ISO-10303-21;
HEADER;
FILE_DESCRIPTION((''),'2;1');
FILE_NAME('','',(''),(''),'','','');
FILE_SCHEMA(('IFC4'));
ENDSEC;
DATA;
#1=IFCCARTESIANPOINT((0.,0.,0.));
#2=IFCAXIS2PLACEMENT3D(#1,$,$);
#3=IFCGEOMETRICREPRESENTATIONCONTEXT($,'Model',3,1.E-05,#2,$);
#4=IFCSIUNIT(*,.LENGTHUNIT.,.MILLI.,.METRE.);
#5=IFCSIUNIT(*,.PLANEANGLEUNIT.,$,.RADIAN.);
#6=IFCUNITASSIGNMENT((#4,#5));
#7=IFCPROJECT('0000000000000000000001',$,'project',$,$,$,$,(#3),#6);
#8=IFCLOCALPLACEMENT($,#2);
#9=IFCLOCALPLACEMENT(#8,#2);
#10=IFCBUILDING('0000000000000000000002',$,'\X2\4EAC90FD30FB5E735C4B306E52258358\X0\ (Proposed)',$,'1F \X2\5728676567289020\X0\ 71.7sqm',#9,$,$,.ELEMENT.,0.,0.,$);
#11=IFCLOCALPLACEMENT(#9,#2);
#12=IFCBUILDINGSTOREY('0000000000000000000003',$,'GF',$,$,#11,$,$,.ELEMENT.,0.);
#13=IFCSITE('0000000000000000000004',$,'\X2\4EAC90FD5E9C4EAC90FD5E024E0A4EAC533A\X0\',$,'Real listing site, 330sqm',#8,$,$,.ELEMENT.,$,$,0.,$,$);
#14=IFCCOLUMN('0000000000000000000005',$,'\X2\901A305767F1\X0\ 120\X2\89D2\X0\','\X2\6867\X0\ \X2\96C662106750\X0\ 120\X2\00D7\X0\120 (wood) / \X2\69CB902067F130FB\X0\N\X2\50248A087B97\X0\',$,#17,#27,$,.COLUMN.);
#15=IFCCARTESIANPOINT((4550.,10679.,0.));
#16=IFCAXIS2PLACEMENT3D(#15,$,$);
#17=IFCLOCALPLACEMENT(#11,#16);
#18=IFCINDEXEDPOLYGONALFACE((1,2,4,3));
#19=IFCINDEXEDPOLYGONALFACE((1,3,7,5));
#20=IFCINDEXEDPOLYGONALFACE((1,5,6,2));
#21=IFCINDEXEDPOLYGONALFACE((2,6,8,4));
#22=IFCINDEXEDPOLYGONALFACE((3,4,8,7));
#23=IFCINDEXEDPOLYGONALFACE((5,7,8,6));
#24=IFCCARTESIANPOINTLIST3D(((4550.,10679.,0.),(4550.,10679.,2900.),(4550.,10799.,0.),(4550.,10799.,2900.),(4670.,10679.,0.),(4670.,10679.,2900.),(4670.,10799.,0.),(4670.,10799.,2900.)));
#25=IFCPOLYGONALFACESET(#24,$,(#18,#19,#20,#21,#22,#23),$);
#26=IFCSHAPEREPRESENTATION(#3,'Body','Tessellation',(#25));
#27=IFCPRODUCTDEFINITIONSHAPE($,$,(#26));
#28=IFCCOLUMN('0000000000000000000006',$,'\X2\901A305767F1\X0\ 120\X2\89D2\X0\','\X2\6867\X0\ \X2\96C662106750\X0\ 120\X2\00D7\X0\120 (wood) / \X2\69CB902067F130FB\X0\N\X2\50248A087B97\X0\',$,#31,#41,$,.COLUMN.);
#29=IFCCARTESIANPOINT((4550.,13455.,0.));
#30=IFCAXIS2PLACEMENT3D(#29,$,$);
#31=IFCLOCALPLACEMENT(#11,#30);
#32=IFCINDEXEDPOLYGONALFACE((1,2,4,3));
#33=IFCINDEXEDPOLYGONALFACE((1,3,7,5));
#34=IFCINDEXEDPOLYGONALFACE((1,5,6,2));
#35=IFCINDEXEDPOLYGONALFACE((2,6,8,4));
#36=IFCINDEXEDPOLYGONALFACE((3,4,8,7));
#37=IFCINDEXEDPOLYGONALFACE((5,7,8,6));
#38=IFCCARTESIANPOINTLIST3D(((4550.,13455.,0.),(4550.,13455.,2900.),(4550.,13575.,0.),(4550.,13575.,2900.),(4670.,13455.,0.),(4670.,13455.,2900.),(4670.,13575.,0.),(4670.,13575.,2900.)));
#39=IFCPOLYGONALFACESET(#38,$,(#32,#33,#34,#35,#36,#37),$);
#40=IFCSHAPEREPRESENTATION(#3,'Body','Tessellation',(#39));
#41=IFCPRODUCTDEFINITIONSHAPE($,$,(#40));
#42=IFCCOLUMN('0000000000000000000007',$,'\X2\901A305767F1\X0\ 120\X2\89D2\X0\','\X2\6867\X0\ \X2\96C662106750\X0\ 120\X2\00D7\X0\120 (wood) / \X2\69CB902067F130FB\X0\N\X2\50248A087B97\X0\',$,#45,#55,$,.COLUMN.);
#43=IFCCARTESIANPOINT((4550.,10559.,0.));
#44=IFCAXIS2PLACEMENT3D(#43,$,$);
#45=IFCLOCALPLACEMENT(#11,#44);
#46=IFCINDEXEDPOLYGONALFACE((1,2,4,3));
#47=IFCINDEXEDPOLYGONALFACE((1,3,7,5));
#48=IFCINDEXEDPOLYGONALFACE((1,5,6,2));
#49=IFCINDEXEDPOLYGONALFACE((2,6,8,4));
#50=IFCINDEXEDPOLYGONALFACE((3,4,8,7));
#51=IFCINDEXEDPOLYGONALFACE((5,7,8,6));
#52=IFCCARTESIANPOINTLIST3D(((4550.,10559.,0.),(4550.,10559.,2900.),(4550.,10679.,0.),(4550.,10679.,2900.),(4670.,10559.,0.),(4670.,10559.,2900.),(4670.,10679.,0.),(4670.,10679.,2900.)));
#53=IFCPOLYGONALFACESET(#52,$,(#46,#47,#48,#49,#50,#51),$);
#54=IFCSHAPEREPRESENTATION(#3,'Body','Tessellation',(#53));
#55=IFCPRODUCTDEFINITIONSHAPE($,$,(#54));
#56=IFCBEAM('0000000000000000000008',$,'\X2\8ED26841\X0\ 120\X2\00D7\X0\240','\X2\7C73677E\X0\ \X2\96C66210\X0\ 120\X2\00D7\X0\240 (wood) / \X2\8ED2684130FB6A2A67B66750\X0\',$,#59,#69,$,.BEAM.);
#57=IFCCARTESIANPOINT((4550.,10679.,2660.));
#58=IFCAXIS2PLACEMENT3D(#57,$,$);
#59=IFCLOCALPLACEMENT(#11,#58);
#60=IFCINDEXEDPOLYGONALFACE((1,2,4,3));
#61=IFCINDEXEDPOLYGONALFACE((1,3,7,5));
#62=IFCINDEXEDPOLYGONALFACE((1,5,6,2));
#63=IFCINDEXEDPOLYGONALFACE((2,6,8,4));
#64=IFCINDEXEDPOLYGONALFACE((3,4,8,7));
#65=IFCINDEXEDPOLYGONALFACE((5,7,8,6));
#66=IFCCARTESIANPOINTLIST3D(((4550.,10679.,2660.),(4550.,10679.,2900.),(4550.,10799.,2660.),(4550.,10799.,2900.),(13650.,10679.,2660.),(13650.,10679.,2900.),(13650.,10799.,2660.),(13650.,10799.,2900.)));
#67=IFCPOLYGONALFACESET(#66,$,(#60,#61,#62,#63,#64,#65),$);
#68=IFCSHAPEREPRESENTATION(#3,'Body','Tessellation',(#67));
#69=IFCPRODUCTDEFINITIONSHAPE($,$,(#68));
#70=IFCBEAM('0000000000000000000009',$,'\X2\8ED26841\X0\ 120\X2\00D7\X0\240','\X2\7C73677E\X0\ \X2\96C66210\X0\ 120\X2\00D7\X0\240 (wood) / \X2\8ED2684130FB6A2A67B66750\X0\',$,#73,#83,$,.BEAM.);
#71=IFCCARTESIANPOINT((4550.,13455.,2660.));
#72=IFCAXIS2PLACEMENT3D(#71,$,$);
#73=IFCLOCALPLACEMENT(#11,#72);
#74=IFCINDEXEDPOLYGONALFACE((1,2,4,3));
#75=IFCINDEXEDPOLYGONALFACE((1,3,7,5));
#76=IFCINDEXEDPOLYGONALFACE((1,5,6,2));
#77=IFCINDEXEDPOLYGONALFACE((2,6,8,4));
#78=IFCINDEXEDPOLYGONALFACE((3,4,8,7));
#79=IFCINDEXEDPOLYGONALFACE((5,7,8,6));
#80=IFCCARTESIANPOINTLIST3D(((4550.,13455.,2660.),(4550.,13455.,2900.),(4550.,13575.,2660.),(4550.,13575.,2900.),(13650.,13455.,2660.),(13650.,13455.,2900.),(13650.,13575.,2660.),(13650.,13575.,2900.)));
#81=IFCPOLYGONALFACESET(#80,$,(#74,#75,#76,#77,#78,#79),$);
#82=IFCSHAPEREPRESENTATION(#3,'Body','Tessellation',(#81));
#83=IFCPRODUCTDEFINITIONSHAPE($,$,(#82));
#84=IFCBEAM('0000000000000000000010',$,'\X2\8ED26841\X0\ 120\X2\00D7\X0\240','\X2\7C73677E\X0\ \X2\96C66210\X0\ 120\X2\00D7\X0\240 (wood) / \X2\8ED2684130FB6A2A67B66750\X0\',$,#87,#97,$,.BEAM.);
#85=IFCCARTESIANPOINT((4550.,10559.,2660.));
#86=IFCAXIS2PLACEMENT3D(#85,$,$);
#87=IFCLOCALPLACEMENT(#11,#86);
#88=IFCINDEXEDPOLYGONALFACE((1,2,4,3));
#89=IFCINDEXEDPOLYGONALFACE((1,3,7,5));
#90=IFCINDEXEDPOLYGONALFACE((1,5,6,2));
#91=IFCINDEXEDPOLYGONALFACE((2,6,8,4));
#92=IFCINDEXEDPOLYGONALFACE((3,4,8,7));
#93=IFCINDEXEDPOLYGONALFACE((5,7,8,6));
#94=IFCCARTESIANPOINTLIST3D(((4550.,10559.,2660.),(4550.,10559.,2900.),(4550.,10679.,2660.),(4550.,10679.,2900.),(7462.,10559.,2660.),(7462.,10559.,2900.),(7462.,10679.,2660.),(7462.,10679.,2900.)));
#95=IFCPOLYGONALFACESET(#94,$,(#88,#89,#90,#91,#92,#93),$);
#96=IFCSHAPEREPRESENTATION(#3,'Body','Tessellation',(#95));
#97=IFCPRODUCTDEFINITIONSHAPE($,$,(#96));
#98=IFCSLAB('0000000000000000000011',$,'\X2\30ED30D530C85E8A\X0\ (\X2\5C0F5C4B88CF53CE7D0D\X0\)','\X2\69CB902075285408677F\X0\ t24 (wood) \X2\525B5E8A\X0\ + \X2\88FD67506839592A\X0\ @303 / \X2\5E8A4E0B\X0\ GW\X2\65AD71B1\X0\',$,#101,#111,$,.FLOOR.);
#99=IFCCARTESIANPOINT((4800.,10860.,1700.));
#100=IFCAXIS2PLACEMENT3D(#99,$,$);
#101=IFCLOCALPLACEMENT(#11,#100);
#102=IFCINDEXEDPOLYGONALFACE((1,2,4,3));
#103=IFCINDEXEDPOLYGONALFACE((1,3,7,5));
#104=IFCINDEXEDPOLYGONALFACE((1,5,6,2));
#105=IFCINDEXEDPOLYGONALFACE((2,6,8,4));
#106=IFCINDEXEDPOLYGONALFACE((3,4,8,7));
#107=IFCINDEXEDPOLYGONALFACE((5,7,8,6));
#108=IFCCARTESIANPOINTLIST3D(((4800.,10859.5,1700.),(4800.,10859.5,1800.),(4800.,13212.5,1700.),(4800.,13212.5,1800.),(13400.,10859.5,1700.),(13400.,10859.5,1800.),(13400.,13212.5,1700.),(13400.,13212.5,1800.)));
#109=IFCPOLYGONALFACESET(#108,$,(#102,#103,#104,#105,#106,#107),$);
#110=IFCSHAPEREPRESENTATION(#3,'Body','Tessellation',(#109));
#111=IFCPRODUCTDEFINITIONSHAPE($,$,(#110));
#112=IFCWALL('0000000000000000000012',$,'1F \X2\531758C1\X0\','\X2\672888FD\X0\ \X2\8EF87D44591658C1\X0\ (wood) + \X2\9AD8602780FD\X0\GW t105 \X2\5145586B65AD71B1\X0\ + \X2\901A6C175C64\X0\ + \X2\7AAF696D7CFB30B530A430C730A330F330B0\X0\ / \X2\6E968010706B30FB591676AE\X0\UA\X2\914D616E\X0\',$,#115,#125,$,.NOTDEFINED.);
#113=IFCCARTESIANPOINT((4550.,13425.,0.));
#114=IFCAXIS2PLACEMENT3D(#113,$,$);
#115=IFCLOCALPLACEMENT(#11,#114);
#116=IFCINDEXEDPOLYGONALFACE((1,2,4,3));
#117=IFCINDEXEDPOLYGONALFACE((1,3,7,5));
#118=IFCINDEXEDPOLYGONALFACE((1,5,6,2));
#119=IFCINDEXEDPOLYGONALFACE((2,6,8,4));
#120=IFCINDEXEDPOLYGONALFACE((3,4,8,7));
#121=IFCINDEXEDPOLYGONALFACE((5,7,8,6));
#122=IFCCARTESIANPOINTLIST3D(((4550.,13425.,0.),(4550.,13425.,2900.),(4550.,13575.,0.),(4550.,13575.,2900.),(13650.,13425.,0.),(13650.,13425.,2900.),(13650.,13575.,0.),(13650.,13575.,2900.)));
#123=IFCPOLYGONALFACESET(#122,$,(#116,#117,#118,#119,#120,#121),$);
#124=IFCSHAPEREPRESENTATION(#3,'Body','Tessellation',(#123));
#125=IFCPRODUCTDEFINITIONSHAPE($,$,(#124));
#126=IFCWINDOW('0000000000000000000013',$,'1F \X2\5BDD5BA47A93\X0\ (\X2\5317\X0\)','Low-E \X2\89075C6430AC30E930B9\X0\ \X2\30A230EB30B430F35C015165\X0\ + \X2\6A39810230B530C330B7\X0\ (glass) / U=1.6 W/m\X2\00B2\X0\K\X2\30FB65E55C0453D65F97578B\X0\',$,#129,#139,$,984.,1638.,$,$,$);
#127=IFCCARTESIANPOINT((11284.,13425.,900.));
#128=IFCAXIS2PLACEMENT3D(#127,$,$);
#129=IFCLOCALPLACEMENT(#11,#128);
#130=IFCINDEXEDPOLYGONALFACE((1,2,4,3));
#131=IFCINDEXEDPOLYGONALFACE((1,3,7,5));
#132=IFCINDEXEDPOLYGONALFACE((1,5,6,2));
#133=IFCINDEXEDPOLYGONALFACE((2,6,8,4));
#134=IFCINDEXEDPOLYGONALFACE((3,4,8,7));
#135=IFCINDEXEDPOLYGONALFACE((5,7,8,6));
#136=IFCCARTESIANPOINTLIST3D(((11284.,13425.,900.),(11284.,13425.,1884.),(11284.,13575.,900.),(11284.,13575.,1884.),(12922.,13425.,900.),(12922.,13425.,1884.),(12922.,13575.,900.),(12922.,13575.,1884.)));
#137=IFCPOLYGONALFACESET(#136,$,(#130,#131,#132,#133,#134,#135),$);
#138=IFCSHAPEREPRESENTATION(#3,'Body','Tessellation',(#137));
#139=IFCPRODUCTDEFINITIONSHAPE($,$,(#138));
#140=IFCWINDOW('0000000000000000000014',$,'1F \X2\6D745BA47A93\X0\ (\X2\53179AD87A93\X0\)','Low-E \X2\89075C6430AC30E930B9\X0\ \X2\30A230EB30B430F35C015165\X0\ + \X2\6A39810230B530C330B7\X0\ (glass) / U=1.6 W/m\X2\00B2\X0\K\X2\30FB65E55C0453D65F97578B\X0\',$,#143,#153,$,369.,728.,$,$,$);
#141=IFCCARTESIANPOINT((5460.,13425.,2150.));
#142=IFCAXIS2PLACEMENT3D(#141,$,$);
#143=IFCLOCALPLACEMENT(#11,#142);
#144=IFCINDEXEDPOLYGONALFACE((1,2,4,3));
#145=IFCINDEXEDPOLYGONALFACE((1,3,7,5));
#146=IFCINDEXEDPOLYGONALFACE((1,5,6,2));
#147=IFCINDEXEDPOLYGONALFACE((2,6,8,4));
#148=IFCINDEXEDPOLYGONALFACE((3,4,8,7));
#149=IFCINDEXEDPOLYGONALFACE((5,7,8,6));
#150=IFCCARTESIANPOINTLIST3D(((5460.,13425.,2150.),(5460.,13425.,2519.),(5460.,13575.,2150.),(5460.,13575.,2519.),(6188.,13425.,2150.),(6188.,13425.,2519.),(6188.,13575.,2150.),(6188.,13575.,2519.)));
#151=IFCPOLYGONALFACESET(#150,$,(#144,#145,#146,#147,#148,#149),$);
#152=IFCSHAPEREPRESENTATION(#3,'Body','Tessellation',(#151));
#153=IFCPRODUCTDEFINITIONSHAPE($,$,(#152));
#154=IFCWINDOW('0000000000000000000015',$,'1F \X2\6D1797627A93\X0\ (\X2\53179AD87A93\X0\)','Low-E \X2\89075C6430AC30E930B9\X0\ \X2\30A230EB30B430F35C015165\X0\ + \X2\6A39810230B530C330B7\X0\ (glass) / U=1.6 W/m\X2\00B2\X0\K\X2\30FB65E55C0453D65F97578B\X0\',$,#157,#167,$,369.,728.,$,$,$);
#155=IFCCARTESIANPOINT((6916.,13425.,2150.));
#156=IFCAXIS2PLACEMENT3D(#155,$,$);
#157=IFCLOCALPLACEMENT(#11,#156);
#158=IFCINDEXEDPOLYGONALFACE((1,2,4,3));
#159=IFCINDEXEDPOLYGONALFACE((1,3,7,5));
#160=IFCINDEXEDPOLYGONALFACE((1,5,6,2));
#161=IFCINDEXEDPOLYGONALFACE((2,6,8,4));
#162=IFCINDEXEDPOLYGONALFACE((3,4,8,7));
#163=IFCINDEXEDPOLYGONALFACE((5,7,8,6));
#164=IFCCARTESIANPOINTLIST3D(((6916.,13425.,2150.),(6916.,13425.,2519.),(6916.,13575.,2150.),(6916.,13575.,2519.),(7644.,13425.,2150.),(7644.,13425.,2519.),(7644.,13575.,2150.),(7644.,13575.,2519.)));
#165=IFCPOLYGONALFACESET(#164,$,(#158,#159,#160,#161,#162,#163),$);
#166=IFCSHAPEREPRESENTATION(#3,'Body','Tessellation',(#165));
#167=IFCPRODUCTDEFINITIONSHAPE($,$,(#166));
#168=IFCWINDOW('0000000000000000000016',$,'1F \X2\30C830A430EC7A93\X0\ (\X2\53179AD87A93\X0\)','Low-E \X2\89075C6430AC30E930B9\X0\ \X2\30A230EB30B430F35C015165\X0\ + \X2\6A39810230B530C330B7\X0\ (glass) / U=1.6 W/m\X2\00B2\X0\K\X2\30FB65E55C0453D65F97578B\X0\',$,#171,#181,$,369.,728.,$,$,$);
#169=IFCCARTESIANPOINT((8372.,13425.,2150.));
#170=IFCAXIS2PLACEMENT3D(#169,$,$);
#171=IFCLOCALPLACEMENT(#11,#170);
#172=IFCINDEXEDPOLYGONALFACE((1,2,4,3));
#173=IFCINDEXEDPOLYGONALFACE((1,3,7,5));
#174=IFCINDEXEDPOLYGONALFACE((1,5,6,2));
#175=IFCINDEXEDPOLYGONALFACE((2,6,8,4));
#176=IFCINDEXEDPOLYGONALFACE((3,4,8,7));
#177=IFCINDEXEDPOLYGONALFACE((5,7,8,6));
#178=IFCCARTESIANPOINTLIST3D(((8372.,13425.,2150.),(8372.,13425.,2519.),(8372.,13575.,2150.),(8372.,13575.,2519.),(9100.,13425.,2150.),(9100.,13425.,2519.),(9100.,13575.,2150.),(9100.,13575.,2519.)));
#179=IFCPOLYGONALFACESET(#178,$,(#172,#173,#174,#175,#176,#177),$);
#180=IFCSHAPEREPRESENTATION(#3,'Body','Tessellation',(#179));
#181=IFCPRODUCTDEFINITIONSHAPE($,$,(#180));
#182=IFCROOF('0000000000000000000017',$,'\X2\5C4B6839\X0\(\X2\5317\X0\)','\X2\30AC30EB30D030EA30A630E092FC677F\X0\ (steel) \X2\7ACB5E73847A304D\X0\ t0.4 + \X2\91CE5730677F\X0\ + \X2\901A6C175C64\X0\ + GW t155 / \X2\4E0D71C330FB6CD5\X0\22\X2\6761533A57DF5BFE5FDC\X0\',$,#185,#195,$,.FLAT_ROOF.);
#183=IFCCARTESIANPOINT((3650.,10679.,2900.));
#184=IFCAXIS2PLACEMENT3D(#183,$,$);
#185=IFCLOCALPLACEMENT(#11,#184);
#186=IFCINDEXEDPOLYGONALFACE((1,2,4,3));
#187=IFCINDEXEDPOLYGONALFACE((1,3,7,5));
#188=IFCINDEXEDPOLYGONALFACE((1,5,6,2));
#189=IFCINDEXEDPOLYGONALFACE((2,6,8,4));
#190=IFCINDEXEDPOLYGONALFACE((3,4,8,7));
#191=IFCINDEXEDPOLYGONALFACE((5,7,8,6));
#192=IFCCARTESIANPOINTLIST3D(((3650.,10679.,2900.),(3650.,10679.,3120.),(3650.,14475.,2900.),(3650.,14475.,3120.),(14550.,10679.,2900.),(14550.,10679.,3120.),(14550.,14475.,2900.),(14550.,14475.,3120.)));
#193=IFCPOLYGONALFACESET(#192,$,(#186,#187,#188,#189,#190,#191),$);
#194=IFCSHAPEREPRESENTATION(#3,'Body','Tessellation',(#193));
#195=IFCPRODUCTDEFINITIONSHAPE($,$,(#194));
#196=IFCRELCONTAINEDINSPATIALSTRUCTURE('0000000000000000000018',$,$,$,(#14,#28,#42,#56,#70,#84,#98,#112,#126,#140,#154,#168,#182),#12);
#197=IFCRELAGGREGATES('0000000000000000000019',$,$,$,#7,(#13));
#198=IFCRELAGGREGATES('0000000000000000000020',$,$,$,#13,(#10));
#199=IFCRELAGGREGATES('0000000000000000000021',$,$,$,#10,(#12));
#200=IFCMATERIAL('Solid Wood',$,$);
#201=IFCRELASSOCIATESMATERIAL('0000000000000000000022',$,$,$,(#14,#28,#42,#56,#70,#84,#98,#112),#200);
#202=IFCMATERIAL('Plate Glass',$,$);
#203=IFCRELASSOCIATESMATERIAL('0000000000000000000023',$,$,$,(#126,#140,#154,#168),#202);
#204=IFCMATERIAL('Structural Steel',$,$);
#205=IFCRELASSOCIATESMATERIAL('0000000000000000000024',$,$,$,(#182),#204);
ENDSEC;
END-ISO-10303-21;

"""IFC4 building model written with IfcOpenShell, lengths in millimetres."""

from ifc_helpers import new_model, si_unit, frame, frame_2d, origin, place, context, project, spatial, rectangle, extrude, material, element, fill, save


model = new_model("IFC4")

# Units and contexts
model_context = context("Model", 3, precision=1e-05, world=origin())
ifc_project = project(units=[si_unit("LENGTHUNIT", "METRE", prefix="MILLI"), si_unit("PLANEANGLEUNIT", "RADIAN")], contexts=[model_context])

# Site, building, storey
site_placement = place(None, origin())
site = spatial("IfcSite", under=ifc_project, at=site_placement, Name="京都府京都市上京区", ObjectType="Real listing site, 330sqm", CompositionType="ELEMENT", RefElevation=0.0)
building_placement = place(site_placement, origin())
building = spatial("IfcBuilding", under=site, at=building_placement, Name="京都・平屋の別荘 (Proposed)", ObjectType="1F 在来木造 71.7sqm", CompositionType="ELEMENT", ElevationOfRefHeight=0.0, ElevationOfTerrain=0.0)
storey_placement = place(building_placement, origin())
storey = spatial("IfcBuildingStorey", under=building, at=storey_placement, Name="GF", CompositionType="ELEMENT", Elevation=0.0)

# Columns
ifc_material_1 = material(Name="Solid Wood")
column_1_placement = place(storey_placement, frame((4550.0, 10679.0, 0.0)))
element("IfcColumn", 1, at=column_1_placement, inside=storey, material=ifc_material_1, Name="通し柱 120角", Description="桧 集成材 120×120 (wood) / 構造柱・N値計算", PredefinedType="COLUMN", context=model_context, shape_type="SweptSolid", body=[
    extrude(rectangle(XDim=120.0, YDim=120.0, at=frame_2d((60.0, 60.0))), frame((4550.0, 10679.0, 0.0)), (0.0, 0.0, 1.0), 2900.0),
])
column_2_placement = place(storey_placement, frame((4550.0, 13455.0, 0.0)))
element("IfcColumn", 2, at=column_2_placement, inside=storey, material=ifc_material_1, Name="通し柱 120角", Description="桧 集成材 120×120 (wood) / 構造柱・N値計算", PredefinedType="COLUMN", context=model_context, shape_type="SweptSolid", body=[
    extrude(rectangle(XDim=120.0, YDim=120.0, at=frame_2d((60.0, 60.0))), frame((4550.0, 13455.0, 0.0)), (0.0, 0.0, 1.0), 2900.0),
])
column_3_placement = place(storey_placement, frame((4550.0, 10559.0, 0.0)))
element("IfcColumn", 3, at=column_3_placement, inside=storey, material=ifc_material_1, Name="通し柱 120角", Description="桧 集成材 120×120 (wood) / 構造柱・N値計算", PredefinedType="COLUMN", context=model_context, shape_type="SweptSolid", body=[
    extrude(rectangle(XDim=120.0, YDim=120.0, at=frame_2d((60.0, 60.0))), frame((4550.0, 10559.0, 0.0)), (0.0, 0.0, 1.0), 2900.0),
])

# Beams
beam_1_placement = place(storey_placement, frame((4550.0, 10679.0, 2660.0)))
element("IfcBeam", 4, at=beam_1_placement, inside=storey, material=ifc_material_1, Name="軒桁 120×240", Description="米松 集成 120×240 (wood) / 軒桁・横架材", PredefinedType="BEAM", context=model_context, shape_type="SweptSolid", body=[
    extrude(rectangle(XDim=9100.0, YDim=120.0, at=frame_2d((4550.0, 60.0))), frame((4550.0, 10679.0, 2660.0)), (0.0, 0.0, 1.0), 240.0),
])
beam_2_placement = place(storey_placement, frame((4550.0, 13455.0, 2660.0)))
element("IfcBeam", 5, at=beam_2_placement, inside=storey, material=ifc_material_1, Name="軒桁 120×240", Description="米松 集成 120×240 (wood) / 軒桁・横架材", PredefinedType="BEAM", context=model_context, shape_type="SweptSolid", body=[
    extrude(rectangle(XDim=9100.0, YDim=120.0, at=frame_2d((4550.0, 60.0))), frame((4550.0, 13455.0, 2660.0)), (0.0, 0.0, 1.0), 240.0),
])
beam_3_placement = place(storey_placement, frame((4550.0, 10559.0, 2660.0)))
element("IfcBeam", 6, at=beam_3_placement, inside=storey, material=ifc_material_1, Name="軒桁 120×240", Description="米松 集成 120×240 (wood) / 軒桁・横架材", PredefinedType="BEAM", context=model_context, shape_type="SweptSolid", body=[
    extrude(rectangle(XDim=2912.0, YDim=120.0, at=frame_2d((1456.0, 60.0))), frame((4550.0, 10559.0, 2660.0)), (0.0, 0.0, 1.0), 240.0),
])

# Slab
slab_1_placement = place(storey_placement, frame((4800.0, 10860.0, 1700.0)))
element("IfcSlab", 7, at=slab_1_placement, inside=storey, material=ifc_material_1, Name="ロフト床 (小屋裏収納)", Description="構造用合板 t24 (wood) 剛床 + 製材根太 @303 / 床下 GW断熱", PredefinedType="FLOOR", context=model_context, shape_type="SweptSolid", body=[
    extrude(rectangle(XDim=8600.0, YDim=2353.0, at=frame_2d((4300.0, 1176.0))), frame((4800.0, 10860.0, 1700.0)), (0.0, 0.0, 1.0), 100.0),
])

# Wall, openings, windows
wall_1_placement = place(storey_placement, frame((4550.0, 13425.0, 0.0)))
wall_1 = element("IfcWall", 8, at=wall_1_placement, inside=storey, material=ifc_material_1, Name="1F 北壁", Description="木製 軸組外壁 (wood) + 高性能GW t105 充填断熱 + 通気層 + 窯業系サイディング / 準耐火・外皮UA配慮", PredefinedType="NOTDEFINED", context=model_context, shape_type="SweptSolid", body=[
    extrude(rectangle(XDim=9100.0, YDim=150.0, at=frame_2d((4550.0, 75.0))), frame((4550.0, 13425.0, 0.0)), (0.0, 0.0, 1.0), 2900.0),
])
opening_1_placement = place(storey_placement, frame((11284.0, 13425.0, 900.0)))
opening_1 = element("IfcOpeningElement", 9, at=opening_1_placement, cuts=wall_1, PredefinedType="NOTDEFINED", context=model_context, shape_type="SweptSolid", body=[
    extrude(rectangle(XDim=1638.0, YDim=150.0, at=frame_2d((819.0, 75.0))), frame((11284.0, 13425.0, 900.0)), (0.0, 0.0, 1.0), 984.0),
])
opening_2_placement = place(storey_placement, frame((5460.0, 13425.0, 2150.0)))
opening_2 = element("IfcOpeningElement", 10, at=opening_2_placement, cuts=wall_1, PredefinedType="NOTDEFINED", context=model_context, shape_type="SweptSolid", body=[
    extrude(rectangle(XDim=728.0, YDim=150.0, at=frame_2d((364.0, 75.0))), frame((5460.0, 13425.0, 2150.0)), (0.0, 0.0, 1.0), 369.0),
])
opening_3_placement = place(storey_placement, frame((6916.0, 13425.0, 2150.0)))
opening_3 = element("IfcOpeningElement", 11, at=opening_3_placement, cuts=wall_1, PredefinedType="NOTDEFINED", context=model_context, shape_type="SweptSolid", body=[
    extrude(rectangle(XDim=728.0, YDim=150.0, at=frame_2d((364.0, 75.0))), frame((6916.0, 13425.0, 2150.0)), (0.0, 0.0, 1.0), 369.0),
])
opening_4_placement = place(storey_placement, frame((8372.0, 13425.0, 2150.0)))
opening_4 = element("IfcOpeningElement", 12, at=opening_4_placement, cuts=wall_1, PredefinedType="NOTDEFINED", context=model_context, shape_type="SweptSolid", body=[
    extrude(rectangle(XDim=728.0, YDim=150.0, at=frame_2d((364.0, 75.0))), frame((8372.0, 13425.0, 2150.0)), (0.0, 0.0, 1.0), 369.0),
])
ifc_material_2 = material(Name="Plate Glass")
window_1_placement = place(storey_placement, frame((11284.0, 13425.0, 900.0)))
window_1 = element("IfcWindow", 13, at=window_1_placement, inside=storey, material=ifc_material_2, Name="1F 寝室窓 (北)", Description="Low-E 複層ガラス アルゴン封入 + 樹脂サッシ (glass) / U=1.6 W/m²K・日射取得型", OverallHeight=984.0, OverallWidth=1638.0, context=model_context, shape_type="SweptSolid", body=[
    extrude(rectangle(XDim=1638.0, YDim=150.0, at=frame_2d((819.0, 75.0))), frame((11284.0, 13425.0, 900.0)), (0.0, 0.0, 1.0), 984.0),
])
fill(opening_1, window_1)
window_2_placement = place(storey_placement, frame((5460.0, 13425.0, 2150.0)))
window_2 = element("IfcWindow", 14, at=window_2_placement, inside=storey, material=ifc_material_2, Name="1F 浴室窓 (北高窓)", Description="Low-E 複層ガラス アルゴン封入 + 樹脂サッシ (glass) / U=1.6 W/m²K・日射取得型", OverallHeight=369.0, OverallWidth=728.0, context=model_context, shape_type="SweptSolid", body=[
    extrude(rectangle(XDim=728.0, YDim=150.0, at=frame_2d((364.0, 75.0))), frame((5460.0, 13425.0, 2150.0)), (0.0, 0.0, 1.0), 369.0),
])
fill(opening_2, window_2)
window_3_placement = place(storey_placement, frame((6916.0, 13425.0, 2150.0)))
window_3 = element("IfcWindow", 15, at=window_3_placement, inside=storey, material=ifc_material_2, Name="1F 洗面窓 (北高窓)", Description="Low-E 複層ガラス アルゴン封入 + 樹脂サッシ (glass) / U=1.6 W/m²K・日射取得型", OverallHeight=369.0, OverallWidth=728.0, context=model_context, shape_type="SweptSolid", body=[
    extrude(rectangle(XDim=728.0, YDim=150.0, at=frame_2d((364.0, 75.0))), frame((6916.0, 13425.0, 2150.0)), (0.0, 0.0, 1.0), 369.0),
])
fill(opening_3, window_3)
window_4_placement = place(storey_placement, frame((8372.0, 13425.0, 2150.0)))
window_4 = element("IfcWindow", 16, at=window_4_placement, inside=storey, material=ifc_material_2, Name="1F トイレ窓 (北高窓)", Description="Low-E 複層ガラス アルゴン封入 + 樹脂サッシ (glass) / U=1.6 W/m²K・日射取得型", OverallHeight=369.0, OverallWidth=728.0, context=model_context, shape_type="SweptSolid", body=[
    extrude(rectangle(XDim=728.0, YDim=150.0, at=frame_2d((364.0, 75.0))), frame((8372.0, 13425.0, 2150.0)), (0.0, 0.0, 1.0), 369.0),
])
fill(opening_4, window_4)

# Roof
ifc_material_3 = material(Name="Structural Steel")
roof_placement = place(storey_placement, frame((3650.0, 10679.0, 2900.0)))
element("IfcRoof", 17, at=roof_placement, inside=storey, material=ifc_material_3, Name="屋根(北)", Description="ガルバリウム鋼板 (steel) 立平葺き t0.4 + 野地板 + 通気層 + GW t155 / 不燃・法22条区域対応", PredefinedType="FLAT_ROOF", context=model_context, shape_type="SweptSolid", body=[
    extrude(rectangle(XDim=10900.0, YDim=3796.0, at=frame_2d((5450.0, 1898.0))), frame((3650.0, 10679.0, 2900.0)), (0.0, 0.0, 1.0), 220.0),
])

save(model, "model.ifc")
